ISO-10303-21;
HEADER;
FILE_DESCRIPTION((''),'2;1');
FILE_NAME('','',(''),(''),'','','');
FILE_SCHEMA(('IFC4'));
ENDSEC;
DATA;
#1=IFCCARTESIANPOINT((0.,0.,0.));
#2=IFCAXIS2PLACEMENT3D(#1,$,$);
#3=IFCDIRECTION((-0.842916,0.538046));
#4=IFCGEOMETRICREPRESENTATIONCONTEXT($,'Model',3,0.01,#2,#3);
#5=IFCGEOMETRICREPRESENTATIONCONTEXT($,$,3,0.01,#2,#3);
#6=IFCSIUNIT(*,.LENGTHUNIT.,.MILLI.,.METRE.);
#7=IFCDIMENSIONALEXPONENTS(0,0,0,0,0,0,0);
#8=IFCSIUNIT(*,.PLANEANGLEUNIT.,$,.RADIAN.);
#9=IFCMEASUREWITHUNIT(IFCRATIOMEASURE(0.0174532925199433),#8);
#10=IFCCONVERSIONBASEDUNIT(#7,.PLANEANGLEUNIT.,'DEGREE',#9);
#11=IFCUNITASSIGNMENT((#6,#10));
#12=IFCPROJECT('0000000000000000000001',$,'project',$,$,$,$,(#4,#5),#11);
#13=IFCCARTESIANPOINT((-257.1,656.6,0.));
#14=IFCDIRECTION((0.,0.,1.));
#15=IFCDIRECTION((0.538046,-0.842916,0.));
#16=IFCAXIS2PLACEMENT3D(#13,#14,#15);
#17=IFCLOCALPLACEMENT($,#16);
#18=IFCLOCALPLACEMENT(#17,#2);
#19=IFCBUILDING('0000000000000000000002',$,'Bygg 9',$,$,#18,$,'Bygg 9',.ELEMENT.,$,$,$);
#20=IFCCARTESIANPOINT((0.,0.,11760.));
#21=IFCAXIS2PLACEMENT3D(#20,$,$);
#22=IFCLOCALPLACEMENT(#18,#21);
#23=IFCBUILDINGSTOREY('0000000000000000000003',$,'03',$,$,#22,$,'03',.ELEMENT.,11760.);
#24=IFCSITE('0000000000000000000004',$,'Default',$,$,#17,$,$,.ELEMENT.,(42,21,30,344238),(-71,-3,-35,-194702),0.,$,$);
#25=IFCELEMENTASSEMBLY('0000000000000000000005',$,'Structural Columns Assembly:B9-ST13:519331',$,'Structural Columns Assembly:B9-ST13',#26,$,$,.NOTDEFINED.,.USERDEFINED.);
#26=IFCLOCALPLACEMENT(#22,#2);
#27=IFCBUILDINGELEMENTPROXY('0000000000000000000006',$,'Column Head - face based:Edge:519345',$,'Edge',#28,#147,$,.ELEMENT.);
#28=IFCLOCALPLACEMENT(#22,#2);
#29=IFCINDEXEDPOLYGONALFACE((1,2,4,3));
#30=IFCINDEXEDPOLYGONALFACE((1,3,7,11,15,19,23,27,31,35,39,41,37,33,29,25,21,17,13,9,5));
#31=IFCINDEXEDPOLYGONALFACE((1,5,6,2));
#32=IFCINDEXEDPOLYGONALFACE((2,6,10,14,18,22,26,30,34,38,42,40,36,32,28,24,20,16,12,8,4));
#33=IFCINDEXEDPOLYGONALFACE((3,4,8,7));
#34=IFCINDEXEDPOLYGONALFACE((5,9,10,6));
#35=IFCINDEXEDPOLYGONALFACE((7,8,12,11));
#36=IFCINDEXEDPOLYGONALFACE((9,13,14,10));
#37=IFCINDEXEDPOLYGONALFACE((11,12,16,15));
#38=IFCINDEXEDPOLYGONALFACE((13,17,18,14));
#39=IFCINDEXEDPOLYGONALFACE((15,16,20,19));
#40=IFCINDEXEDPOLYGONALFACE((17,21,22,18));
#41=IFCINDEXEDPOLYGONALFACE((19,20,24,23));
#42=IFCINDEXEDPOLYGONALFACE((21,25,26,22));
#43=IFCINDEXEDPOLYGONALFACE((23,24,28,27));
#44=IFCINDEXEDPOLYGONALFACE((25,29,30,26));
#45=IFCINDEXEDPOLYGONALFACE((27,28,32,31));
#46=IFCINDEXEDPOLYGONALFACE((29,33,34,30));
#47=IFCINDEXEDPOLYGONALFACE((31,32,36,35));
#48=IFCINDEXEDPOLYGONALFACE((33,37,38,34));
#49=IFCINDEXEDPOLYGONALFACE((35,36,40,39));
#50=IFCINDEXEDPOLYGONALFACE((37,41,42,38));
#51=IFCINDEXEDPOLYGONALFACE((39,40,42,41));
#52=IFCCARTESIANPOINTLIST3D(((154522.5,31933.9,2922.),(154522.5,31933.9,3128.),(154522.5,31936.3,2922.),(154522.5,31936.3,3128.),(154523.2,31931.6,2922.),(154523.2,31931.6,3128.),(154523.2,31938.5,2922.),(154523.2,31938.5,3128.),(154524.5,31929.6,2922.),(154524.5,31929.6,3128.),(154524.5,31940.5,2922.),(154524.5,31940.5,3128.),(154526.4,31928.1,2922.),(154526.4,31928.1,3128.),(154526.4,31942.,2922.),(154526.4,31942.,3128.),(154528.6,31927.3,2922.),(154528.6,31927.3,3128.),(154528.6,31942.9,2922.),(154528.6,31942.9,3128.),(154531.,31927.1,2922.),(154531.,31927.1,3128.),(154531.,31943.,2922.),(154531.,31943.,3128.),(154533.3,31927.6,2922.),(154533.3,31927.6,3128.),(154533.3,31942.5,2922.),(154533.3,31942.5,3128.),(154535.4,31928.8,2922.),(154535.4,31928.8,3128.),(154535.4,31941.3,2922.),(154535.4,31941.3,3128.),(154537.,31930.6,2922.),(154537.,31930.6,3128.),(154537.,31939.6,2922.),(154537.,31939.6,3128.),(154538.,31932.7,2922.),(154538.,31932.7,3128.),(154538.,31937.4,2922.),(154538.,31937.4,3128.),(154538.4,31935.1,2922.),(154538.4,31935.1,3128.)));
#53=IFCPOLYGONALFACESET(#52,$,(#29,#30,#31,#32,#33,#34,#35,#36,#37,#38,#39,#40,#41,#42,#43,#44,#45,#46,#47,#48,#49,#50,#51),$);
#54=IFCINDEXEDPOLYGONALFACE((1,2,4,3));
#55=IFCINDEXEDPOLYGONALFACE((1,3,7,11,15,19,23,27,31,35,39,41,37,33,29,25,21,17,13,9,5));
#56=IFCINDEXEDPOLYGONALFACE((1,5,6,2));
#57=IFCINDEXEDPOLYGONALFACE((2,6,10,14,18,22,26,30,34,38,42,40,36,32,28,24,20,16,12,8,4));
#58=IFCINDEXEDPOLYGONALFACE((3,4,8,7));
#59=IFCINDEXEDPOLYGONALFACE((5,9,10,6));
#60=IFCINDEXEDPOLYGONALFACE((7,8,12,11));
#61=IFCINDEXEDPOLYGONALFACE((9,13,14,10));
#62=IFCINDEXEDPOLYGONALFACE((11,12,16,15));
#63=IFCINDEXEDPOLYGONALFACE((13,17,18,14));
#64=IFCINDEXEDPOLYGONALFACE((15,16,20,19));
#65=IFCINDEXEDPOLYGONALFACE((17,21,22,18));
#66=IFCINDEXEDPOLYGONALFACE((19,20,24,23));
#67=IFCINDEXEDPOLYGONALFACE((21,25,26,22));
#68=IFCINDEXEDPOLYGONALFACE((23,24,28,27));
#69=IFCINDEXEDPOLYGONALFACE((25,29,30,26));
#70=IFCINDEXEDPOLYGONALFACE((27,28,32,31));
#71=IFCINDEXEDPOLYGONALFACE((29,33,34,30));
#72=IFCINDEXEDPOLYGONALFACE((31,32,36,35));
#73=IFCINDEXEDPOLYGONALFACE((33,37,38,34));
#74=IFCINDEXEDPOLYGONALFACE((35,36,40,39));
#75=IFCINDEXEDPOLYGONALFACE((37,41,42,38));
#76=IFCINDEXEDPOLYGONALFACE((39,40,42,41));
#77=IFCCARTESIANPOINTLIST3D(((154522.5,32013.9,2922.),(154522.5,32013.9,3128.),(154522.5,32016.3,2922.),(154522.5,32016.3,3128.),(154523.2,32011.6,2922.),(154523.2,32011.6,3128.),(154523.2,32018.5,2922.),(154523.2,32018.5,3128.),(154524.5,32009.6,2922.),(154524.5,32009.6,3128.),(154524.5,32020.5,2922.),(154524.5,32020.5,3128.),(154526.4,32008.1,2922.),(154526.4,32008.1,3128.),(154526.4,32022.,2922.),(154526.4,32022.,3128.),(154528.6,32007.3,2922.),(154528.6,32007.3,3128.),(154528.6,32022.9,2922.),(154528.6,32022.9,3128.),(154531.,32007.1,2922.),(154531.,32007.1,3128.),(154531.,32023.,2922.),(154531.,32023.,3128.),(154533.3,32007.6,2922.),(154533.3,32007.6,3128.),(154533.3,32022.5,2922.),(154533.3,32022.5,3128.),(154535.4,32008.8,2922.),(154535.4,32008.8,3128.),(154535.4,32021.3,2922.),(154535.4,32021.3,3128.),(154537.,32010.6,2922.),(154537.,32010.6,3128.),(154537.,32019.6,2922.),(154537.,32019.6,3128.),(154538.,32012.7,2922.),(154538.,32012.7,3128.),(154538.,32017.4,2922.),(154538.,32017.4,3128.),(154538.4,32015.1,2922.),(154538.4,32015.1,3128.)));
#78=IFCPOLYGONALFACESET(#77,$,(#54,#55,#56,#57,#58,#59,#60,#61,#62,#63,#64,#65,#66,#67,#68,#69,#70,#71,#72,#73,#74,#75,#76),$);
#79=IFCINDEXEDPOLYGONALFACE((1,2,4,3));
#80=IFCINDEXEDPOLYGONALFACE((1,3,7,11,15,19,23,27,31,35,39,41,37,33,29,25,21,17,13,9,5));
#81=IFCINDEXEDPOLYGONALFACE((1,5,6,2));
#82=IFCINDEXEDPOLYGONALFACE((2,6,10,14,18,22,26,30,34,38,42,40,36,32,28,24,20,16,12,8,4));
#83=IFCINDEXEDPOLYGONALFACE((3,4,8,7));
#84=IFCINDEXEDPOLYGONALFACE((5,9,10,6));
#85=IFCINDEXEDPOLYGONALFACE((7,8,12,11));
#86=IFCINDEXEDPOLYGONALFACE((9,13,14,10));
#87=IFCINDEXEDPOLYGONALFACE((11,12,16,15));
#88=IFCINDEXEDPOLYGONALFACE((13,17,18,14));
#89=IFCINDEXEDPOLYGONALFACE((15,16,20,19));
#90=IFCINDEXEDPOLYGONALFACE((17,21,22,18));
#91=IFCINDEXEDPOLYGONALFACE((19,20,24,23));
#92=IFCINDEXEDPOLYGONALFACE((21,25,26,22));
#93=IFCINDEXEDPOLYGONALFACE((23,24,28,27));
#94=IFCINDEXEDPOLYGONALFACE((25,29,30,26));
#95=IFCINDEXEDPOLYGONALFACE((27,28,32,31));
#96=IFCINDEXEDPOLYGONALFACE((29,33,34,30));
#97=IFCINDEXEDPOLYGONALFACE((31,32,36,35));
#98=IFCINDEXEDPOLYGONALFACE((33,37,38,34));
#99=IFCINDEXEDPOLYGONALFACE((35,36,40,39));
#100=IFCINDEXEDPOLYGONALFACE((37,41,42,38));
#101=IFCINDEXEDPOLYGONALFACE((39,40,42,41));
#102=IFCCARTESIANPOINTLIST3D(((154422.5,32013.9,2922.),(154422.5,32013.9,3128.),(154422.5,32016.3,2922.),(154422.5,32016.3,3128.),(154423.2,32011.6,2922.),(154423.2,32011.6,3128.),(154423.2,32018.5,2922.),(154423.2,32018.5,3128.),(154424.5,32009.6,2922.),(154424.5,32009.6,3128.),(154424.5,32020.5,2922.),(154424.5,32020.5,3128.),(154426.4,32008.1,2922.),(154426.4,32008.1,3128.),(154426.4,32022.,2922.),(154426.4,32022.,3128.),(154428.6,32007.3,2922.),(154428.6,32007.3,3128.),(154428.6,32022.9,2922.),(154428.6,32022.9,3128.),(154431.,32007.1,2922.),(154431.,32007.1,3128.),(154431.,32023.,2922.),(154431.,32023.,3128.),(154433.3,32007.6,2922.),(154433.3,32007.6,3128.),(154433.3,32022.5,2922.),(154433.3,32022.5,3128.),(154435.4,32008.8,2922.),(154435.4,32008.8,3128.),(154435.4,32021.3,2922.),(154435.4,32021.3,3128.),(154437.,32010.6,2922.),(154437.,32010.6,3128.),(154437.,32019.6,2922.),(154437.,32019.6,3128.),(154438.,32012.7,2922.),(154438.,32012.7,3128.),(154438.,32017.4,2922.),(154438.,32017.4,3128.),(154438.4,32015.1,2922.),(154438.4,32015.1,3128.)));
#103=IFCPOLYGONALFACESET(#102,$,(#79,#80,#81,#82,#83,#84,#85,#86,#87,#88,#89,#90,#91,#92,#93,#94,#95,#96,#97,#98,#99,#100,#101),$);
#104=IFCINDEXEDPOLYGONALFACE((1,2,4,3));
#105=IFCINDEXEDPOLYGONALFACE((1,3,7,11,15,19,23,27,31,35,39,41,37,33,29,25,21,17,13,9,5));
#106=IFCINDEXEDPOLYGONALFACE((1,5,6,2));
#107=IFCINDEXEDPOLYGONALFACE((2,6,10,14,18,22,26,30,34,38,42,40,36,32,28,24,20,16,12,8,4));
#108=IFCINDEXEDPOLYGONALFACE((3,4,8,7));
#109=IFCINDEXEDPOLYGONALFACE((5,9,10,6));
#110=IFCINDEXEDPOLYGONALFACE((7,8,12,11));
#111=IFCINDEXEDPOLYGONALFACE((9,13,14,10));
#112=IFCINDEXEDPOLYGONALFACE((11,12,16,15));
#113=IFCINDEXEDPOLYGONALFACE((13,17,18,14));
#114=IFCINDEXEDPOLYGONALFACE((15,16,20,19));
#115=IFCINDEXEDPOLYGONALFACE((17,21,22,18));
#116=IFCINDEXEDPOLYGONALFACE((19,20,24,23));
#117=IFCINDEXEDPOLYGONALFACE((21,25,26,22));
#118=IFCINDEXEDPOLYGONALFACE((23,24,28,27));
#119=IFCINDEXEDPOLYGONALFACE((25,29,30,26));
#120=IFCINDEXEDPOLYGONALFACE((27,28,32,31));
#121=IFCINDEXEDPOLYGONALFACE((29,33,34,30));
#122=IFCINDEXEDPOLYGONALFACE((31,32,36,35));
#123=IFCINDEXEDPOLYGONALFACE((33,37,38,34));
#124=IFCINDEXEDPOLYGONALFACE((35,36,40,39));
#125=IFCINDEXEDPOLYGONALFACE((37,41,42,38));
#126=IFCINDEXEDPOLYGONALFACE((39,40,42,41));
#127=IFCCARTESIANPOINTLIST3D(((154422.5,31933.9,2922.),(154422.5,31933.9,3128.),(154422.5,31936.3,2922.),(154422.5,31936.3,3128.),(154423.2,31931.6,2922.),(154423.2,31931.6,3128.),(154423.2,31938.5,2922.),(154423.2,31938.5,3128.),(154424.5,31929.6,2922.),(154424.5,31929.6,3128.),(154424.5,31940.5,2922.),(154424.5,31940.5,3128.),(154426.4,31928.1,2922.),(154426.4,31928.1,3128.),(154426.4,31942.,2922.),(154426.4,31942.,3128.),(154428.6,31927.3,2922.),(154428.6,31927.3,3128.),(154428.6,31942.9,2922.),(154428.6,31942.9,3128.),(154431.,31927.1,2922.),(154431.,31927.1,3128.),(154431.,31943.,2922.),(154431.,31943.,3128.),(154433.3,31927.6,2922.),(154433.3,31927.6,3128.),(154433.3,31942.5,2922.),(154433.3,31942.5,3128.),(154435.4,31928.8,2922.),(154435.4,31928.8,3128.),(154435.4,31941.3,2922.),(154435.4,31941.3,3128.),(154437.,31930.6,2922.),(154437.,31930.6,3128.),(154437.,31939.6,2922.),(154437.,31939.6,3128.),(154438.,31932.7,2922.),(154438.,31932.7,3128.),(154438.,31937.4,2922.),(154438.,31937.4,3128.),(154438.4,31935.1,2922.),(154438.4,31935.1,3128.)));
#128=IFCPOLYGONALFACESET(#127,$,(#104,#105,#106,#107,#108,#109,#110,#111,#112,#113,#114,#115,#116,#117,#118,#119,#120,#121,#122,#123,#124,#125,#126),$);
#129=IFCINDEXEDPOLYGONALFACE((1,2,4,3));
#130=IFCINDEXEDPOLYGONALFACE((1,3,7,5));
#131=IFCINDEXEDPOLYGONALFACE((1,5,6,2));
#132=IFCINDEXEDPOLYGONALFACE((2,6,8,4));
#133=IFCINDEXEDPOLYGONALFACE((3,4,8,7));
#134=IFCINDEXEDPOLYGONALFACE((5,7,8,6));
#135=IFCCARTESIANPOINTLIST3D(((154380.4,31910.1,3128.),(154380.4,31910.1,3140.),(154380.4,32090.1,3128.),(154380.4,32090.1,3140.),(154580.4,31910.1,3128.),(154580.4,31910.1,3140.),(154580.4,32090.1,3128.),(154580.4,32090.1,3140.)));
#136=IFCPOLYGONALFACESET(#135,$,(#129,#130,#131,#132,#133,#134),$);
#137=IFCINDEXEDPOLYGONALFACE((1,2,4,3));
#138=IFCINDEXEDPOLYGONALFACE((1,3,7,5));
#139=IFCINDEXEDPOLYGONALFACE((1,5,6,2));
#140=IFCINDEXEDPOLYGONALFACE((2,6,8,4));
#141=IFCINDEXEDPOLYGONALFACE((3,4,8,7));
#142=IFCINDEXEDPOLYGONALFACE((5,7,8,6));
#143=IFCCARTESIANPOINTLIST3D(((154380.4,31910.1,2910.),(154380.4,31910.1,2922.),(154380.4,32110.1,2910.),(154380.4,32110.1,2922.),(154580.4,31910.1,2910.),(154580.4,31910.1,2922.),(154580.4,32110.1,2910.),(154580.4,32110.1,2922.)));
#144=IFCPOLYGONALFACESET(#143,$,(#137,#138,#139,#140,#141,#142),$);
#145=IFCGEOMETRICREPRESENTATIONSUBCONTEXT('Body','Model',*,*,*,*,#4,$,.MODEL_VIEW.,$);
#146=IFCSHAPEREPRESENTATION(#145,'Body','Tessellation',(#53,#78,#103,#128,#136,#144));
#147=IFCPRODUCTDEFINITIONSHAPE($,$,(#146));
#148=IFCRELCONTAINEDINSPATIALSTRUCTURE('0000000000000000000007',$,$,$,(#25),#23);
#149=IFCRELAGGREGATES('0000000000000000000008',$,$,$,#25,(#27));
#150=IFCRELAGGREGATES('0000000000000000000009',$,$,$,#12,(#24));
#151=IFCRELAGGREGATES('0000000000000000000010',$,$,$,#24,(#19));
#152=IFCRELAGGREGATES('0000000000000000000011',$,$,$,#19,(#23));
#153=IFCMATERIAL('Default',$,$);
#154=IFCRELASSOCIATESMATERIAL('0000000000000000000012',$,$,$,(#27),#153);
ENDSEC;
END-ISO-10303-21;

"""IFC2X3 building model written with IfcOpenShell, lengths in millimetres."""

from ifc_helpers import new_model, entity, si_unit, converted_unit, direction, frame, frame_2d, origin, origin_2d_with_axis, place, context, subcontext, project, spatial, rectangle, circle, extrude, source, transform, mapped, material, element, aggregate, save


model = new_model("IFC2X3")

# Units and contexts
model_context = context("Model", 3, precision=0.01, world=origin(), true_north=direction((-0.842916, 0.538046)))
context_of_model = context(None, 3, precision=0.01, world=origin(), true_north=direction((-0.842916, 0.538046)))
body_context = subcontext(model_context, "Body", "Model", "MODEL_VIEW")
ifc_project = project(units=[si_unit("LENGTHUNIT", "METRE", prefix="MILLI"), converted_unit("PLANEANGLEUNIT", "DEGREE", entity("IfcRatioMeasure", 0.0174532925199433), si_unit("PLANEANGLEUNIT", "RADIAN"), dimensions=[0, 0, 0, 0, 0, 0, 0])], contexts=[model_context, context_of_model])

# Site, building, storey
site_placement = place(None, frame((-257.1, 656.6, 0.0), z_axis=(0.0, 0.0, 1.0), x_axis=(0.538046, -0.842916, 0.0)))
site = spatial("IfcSite", under=ifc_project, at=site_placement, Name="Default", CompositionType="ELEMENT", RefLatitude=(42, 21, 30, 344238), RefLongitude=(-71, -3, -35, -194702), RefElevation=0.0)
building_placement = place(site_placement, origin())
building = spatial("IfcBuilding", under=site, at=building_placement, Name="Bygg 9", LongName="Bygg 9", CompositionType="ELEMENT")
storey_placement = place(building_placement, frame((0.0, 0.0, 11760.0)))
storey = spatial("IfcBuildingStorey", under=building, at=storey_placement, Name="03", LongName="03", CompositionType="ELEMENT", Elevation=11760.0)

# Shared definitions
ifc_material_1 = material(Name="Default")

# Element assembly, building element proxy
assembly_1_placement = place(storey_placement, origin())
assembly_1 = element("IfcElementAssembly", 1, at=assembly_1_placement, inside=storey, Name="Structural Columns Assembly:B9-ST13:519331", ObjectType="Structural Columns Assembly:B9-ST13", AssemblyPlace="NOTDEFINED", PredefinedType="USERDEFINED")
shared_shape_1 = source(origin(), body_context, "Body", "SweptSolid", [
    extrude(circle(Radius=8.0, at=frame_2d((0.0, 0.0), x_axis=(1.0, 0.0))), frame((50.0, -135.0, 12.0)), (0.0, 0.0, 1.0), 206.0),
    extrude(circle(Radius=8.0, at=frame_2d((0.0, 0.0), x_axis=(1.0, 0.0))), frame((50.0, -55.0, 12.0)), (0.0, 0.0, 1.0), 206.0),
    extrude(circle(Radius=8.0, at=frame_2d((0.0, 0.0), x_axis=(1.0, 0.0))), frame((-50.0, -55.0, 12.0)), (0.0, 0.0, 1.0), 206.0),
    extrude(circle(Radius=8.0, at=frame_2d((0.0, 0.0), x_axis=(1.0, 0.0))), frame((-50.0, -135.0, 12.0)), (0.0, 0.0, 1.0), 206.0),
    extrude(rectangle(XDim=200.0, YDim=180.0, at=origin_2d_with_axis()), frame((0.0, -70.0, 218.0), z_axis=(0.0, 0.0, 1.0), x_axis=(-1.0, 0.0, 0.0)), (0.0, 0.0, 1.0), 12.0),
    extrude(rectangle(XDim=200.0, YDim=200.0, at=origin_2d_with_axis()), frame((0.0, -60.0, 0.0), z_axis=(0.0, 0.0, 1.0), x_axis=(0.0, 1.0, 0.0)), (0.0, 0.0, 1.0), 12.0),
])
proxy_1_placement = place(assembly_1_placement, frame((154480.4, 32070.1, 2910.0)))
proxy_1 = element("IfcBuildingElementProxy", 2, at=proxy_1_placement, material=ifc_material_1, Name="Column Head - face based:Edge:519345", ObjectType="Edge", CompositionType="ELEMENT", context=body_context, shape_type="MappedRepresentation", body=[
    mapped(shared_shape_1, transform((0.0, 0.0, 0.0), scale=1.0)),
])
aggregate(assembly_1, [proxy_1])

save(model, "model.ifc")
